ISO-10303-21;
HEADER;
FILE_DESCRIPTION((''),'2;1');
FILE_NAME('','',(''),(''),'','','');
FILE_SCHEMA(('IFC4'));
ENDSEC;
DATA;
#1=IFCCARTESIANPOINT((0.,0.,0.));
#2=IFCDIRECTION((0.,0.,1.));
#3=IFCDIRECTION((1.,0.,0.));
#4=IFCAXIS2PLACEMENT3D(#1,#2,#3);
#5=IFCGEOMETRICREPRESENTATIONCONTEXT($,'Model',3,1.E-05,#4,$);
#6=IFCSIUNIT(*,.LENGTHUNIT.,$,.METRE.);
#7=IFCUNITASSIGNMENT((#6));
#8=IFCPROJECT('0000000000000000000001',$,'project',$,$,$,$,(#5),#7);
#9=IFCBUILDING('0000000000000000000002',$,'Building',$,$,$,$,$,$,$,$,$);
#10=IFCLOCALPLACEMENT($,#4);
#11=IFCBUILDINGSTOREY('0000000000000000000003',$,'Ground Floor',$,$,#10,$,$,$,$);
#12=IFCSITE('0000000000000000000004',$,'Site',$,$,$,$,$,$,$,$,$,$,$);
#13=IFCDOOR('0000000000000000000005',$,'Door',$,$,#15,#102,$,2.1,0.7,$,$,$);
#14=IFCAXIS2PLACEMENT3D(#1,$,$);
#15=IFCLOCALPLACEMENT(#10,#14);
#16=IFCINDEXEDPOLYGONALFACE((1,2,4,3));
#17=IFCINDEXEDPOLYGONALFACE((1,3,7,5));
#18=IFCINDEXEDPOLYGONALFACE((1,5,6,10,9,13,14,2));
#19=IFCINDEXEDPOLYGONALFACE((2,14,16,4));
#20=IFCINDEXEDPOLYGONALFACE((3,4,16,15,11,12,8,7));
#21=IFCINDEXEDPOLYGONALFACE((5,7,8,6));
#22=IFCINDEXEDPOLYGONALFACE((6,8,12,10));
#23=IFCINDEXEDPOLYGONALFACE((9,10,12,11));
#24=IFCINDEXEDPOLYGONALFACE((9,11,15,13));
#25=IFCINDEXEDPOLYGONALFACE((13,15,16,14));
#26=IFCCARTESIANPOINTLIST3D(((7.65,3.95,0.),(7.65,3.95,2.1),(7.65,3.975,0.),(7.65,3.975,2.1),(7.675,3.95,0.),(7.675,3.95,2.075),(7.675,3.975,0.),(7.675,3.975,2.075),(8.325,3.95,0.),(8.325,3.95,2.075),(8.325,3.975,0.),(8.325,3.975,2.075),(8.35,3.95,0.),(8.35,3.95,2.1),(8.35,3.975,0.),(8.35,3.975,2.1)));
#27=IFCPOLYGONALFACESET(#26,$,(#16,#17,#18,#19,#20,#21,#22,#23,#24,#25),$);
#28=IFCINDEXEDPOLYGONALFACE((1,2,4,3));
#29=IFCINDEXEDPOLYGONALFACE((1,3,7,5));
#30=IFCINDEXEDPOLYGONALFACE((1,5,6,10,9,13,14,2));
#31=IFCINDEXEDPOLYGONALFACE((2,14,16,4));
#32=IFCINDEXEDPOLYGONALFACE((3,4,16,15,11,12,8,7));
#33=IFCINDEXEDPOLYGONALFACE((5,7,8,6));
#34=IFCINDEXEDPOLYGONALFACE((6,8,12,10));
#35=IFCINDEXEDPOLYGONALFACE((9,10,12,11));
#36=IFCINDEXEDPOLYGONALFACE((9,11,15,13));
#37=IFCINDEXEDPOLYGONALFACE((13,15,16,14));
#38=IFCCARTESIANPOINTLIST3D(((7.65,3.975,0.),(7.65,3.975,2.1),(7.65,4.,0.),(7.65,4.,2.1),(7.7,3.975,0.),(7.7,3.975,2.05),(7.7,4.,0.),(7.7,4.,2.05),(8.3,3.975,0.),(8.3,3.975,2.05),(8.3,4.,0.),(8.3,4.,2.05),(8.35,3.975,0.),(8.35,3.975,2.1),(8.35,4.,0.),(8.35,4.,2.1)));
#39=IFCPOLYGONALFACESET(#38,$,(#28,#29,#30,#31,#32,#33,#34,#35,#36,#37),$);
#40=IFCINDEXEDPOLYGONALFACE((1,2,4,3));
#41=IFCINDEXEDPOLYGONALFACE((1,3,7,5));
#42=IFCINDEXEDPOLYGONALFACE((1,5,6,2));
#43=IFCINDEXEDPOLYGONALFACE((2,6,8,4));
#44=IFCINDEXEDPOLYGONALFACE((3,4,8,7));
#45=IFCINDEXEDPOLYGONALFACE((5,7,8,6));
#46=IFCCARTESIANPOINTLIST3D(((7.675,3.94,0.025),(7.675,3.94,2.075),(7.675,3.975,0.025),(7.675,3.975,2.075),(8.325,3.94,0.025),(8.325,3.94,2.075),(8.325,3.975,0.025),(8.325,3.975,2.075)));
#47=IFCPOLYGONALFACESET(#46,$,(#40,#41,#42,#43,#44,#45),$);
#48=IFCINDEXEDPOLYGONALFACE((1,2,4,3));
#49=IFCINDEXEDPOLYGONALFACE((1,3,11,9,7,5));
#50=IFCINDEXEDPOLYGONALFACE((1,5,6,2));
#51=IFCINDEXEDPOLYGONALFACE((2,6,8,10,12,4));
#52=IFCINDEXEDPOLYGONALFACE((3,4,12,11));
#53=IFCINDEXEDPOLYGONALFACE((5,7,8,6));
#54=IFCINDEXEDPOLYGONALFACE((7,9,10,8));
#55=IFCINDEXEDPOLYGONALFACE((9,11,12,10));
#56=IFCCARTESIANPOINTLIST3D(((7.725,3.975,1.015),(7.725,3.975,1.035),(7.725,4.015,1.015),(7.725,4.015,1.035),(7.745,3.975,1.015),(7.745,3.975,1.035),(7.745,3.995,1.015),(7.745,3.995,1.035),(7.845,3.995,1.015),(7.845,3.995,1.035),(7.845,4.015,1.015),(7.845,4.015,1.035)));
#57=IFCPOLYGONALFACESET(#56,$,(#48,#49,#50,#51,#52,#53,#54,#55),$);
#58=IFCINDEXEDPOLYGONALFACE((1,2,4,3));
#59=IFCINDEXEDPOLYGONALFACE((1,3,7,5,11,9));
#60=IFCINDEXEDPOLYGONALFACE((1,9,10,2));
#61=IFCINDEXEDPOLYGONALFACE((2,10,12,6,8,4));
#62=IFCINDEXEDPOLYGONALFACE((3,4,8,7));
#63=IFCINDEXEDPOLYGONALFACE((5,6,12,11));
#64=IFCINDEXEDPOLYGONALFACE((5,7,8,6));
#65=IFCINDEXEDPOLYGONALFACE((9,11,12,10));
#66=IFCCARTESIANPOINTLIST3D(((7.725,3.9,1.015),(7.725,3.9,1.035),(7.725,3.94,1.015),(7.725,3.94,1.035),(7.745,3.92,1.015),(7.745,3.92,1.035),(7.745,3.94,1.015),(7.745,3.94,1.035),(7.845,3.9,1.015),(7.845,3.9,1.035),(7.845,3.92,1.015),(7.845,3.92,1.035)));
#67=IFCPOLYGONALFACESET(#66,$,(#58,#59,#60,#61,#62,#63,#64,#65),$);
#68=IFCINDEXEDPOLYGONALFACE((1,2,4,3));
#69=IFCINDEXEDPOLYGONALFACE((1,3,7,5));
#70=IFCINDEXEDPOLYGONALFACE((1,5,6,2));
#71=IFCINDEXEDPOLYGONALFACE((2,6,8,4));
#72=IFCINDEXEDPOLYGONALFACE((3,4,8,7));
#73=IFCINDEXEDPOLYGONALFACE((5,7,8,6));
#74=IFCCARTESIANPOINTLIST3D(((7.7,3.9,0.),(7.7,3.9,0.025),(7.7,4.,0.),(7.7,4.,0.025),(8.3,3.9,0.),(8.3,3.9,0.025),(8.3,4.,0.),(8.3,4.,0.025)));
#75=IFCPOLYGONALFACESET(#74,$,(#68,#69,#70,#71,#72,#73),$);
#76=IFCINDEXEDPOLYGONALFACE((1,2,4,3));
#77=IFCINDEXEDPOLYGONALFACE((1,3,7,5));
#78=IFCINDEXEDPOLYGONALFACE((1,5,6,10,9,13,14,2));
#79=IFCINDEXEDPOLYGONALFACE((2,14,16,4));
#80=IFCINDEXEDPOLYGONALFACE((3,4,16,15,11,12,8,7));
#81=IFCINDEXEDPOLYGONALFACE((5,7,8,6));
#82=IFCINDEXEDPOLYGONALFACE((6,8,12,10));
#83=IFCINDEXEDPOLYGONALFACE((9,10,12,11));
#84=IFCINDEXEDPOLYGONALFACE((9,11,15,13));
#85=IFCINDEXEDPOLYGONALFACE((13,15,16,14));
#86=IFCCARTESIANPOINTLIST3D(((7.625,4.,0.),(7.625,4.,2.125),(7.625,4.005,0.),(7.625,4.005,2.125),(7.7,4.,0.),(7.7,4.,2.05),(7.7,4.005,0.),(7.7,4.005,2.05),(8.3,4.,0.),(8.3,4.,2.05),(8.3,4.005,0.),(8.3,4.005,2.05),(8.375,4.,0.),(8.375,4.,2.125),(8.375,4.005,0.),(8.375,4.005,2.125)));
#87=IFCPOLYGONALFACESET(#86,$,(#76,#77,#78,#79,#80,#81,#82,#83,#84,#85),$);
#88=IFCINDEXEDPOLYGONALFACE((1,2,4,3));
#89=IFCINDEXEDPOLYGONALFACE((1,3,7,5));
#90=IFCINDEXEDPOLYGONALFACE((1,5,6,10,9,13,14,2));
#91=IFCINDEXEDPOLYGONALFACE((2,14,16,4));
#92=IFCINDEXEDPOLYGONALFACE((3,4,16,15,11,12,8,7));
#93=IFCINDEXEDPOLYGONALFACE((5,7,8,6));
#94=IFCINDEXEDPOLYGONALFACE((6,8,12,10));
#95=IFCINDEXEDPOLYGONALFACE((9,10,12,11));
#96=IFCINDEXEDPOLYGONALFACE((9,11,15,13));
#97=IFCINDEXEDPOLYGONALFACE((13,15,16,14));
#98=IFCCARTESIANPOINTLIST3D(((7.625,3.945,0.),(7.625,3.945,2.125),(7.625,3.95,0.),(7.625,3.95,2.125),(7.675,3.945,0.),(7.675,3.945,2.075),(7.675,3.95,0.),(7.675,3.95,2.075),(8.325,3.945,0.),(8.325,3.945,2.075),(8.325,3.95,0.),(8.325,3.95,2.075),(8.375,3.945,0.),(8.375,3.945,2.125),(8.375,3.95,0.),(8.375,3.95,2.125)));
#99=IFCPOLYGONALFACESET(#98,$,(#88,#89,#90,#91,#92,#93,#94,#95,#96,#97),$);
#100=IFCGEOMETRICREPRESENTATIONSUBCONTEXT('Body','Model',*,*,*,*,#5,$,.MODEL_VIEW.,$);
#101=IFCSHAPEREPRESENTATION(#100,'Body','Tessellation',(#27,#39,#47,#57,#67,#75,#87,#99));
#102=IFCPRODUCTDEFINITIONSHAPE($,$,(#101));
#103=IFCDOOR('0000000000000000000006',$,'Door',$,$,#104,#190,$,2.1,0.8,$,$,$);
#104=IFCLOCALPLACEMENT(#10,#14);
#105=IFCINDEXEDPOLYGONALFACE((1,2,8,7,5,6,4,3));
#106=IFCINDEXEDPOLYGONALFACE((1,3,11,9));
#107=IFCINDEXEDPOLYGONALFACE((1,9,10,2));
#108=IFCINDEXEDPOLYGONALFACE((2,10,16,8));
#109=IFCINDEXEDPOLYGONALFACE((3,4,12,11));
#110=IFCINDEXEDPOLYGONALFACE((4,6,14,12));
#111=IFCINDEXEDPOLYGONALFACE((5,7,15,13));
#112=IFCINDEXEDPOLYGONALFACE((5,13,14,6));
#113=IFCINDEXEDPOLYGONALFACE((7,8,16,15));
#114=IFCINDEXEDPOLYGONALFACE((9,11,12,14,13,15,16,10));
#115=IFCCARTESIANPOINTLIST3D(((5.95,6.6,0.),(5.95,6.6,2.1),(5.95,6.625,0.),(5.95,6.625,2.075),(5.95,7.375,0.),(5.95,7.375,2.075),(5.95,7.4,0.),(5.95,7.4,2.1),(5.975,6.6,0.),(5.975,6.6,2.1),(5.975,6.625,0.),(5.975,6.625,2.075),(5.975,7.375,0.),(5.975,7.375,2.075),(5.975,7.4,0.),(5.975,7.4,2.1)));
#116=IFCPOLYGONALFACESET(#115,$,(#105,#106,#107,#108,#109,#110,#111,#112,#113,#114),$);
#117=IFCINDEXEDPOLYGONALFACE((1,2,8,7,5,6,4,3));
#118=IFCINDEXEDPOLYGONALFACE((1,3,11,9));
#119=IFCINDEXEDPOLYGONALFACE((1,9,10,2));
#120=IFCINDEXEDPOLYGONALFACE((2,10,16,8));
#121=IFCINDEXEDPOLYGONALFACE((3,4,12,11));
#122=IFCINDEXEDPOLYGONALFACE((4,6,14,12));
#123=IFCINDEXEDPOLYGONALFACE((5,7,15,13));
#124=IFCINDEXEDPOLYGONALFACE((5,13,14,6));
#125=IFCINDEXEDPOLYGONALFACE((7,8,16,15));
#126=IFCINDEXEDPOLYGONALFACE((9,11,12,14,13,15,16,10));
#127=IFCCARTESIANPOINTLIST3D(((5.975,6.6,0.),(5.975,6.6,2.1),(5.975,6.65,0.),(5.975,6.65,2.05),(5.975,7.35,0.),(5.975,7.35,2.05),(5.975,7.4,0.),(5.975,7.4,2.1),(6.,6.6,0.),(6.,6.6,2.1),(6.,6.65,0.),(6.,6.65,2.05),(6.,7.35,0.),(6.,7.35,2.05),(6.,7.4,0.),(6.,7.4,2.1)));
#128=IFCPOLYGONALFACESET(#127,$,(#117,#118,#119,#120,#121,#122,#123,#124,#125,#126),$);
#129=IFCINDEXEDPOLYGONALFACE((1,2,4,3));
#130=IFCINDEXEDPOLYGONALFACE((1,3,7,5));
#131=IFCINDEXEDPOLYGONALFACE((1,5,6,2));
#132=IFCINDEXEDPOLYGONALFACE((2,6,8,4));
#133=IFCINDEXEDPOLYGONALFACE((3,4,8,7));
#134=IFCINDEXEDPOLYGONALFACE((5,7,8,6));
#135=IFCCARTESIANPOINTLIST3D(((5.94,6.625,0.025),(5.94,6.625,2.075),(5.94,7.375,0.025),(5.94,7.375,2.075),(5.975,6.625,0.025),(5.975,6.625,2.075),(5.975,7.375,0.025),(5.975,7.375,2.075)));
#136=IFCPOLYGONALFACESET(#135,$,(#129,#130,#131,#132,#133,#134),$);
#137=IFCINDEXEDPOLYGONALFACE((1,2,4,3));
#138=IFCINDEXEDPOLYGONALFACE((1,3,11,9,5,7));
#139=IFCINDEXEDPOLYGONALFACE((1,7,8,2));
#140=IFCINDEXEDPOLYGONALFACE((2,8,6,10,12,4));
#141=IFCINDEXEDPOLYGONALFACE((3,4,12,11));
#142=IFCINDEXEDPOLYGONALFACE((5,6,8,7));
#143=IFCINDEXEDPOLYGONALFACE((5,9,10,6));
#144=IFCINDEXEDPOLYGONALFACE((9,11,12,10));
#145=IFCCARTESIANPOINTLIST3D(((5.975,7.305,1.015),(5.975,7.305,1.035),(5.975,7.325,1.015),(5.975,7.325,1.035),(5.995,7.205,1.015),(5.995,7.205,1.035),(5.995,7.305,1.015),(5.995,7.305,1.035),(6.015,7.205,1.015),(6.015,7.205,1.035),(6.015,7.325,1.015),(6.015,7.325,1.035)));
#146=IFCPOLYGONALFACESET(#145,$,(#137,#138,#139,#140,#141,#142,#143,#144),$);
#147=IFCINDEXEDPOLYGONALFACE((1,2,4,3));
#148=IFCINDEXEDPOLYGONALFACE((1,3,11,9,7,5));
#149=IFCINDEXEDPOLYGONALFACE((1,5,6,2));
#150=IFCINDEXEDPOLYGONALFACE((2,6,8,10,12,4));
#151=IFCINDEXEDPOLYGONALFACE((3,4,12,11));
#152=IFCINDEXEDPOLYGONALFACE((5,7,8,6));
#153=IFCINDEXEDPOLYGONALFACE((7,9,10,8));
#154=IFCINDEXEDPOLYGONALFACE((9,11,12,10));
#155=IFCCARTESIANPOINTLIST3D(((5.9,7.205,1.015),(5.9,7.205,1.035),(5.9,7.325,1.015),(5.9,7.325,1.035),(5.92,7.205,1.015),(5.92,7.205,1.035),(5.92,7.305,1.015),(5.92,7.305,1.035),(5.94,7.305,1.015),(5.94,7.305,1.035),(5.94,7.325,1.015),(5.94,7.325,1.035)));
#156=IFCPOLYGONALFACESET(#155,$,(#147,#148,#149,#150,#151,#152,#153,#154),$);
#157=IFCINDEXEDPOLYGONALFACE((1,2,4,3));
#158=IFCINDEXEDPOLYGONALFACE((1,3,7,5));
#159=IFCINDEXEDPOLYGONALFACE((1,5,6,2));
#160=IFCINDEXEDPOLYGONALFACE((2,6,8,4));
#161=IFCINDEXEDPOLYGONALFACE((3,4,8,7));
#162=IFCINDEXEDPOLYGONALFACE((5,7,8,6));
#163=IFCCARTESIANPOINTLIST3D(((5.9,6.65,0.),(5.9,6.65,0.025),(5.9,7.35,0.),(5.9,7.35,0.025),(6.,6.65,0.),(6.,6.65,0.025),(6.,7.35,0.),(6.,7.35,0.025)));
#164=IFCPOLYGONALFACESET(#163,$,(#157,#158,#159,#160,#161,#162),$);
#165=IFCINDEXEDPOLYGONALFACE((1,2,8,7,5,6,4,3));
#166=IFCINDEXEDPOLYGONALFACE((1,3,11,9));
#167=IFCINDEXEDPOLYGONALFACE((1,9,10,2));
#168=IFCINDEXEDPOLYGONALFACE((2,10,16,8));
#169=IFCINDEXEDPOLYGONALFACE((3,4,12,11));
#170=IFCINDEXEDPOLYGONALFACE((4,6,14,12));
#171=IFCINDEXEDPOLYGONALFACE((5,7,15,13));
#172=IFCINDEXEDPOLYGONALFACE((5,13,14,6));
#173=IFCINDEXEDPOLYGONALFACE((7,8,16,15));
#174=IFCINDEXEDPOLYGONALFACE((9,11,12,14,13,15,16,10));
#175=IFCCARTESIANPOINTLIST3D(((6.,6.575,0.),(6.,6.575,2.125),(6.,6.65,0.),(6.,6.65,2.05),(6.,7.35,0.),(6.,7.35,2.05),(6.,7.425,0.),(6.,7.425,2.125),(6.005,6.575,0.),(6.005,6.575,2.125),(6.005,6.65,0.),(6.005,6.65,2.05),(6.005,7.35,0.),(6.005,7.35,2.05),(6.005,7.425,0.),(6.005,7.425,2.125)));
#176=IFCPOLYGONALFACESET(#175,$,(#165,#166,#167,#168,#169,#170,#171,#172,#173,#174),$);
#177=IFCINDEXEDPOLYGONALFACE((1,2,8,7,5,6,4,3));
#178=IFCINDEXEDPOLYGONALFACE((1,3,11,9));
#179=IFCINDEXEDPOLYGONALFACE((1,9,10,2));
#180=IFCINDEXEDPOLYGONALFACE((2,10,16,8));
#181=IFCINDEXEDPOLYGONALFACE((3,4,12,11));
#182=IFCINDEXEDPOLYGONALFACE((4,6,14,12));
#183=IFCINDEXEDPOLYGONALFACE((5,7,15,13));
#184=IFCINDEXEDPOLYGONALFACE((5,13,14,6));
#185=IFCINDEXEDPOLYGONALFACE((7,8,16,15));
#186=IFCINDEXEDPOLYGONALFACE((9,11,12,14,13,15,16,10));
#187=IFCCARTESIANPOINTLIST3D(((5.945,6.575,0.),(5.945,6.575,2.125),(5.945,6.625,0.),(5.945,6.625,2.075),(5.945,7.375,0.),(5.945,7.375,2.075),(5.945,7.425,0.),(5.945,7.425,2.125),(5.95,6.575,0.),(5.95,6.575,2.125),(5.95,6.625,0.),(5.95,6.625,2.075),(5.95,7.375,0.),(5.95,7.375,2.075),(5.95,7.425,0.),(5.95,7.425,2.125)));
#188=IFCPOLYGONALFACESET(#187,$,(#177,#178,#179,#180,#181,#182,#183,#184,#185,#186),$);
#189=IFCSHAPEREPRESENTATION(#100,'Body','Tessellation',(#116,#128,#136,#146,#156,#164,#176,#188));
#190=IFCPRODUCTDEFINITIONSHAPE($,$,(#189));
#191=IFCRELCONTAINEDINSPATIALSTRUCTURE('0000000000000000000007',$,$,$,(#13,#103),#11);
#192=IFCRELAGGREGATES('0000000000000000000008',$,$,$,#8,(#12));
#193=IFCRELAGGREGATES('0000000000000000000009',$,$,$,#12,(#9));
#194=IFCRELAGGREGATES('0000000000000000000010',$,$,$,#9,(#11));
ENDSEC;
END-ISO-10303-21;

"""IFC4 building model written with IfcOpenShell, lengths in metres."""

from ifc_helpers import new_model, si_unit, frame, origin_with_axes, place, context, subcontext, project, spatial, line, indexed_curve, outline, extrude, element, save


model = new_model("IFC4")

# Units and contexts
model_context = context("Model", 3, precision=1e-05, world=origin_with_axes())
body_context = subcontext(model_context, "Body", "Model", "MODEL_VIEW")
ifc_project = project(units=[si_unit("LENGTHUNIT", "METRE")], contexts=[model_context])

# Site, building, storey
site = spatial("IfcSite", under=ifc_project, Name="Site")
building = spatial("IfcBuilding", under=site, Name="Building")
storey_placement = place(None, origin_with_axes())
storey = spatial("IfcBuildingStorey", under=building, at=storey_placement, Name="Ground Floor")

# Doors
door_1_placement = place(storey_placement, frame((8.35, 4.0, 0.0), z_axis=(0.0, 0.0, 1.0), x_axis=(-1.0, 0.0, 0.0)))
element("IfcDoor", 1, at=door_1_placement, inside=storey, Name="Door", OverallHeight=2.1, OverallWidth=0.7, context=body_context, shape_type="SweptSolid", body=[
    extrude(outline(indexed_curve([(0.0, 0.0), (0.0, 2.1), (0.7, 2.1), (0.7, 0.0), (0.675, 0.0), (0.675, 2.075), (0.025, 2.075), (0.025, 0.0)], segments=[line(1, 2, 3, 4, 5, 6, 7, 8, 1)])), frame((0.0, 0.025, 0.0), z_axis=(0.0, -1.0, 0.0), x_axis=(1.0, 0.0, 0.0)), (0.0, 0.0, -1.0), 0.025),
    extrude(outline(indexed_curve([(0.0, 0.0), (0.0, 2.1), (0.7, 2.1), (0.7, 0.0), (0.65, 0.0), (0.65, 2.05), (0.05, 2.05), (0.05, 0.0)], segments=[line(1, 2, 3, 4, 5, 6, 7, 8, 1)])), frame((0.0, 0.0, 0.0), z_axis=(0.0, -1.0, 0.0), x_axis=(1.0, 0.0, 0.0)), (0.0, 0.0, -1.0), 0.025),
    extrude(outline(indexed_curve([(0.0, 0.0), (0.65, 0.0), (0.65, 0.035), (0.0, 0.035)], segments=[line(1, 2, 3, 4, 1)])), frame((0.025, 0.025, 0.025), z_axis=(0.0, 0.0, 1.0), x_axis=(1.0, 0.0, 0.0)), (0.0, 0.0, 1.0), 2.05),
    extrude(outline(indexed_curve([(0.0, 0.0), (0.0, -0.04), (-0.12, -0.04), (-0.12, -0.02), (-0.02, -0.02), (-0.02, 0.0)], segments=[line(1, 2, 3, 4, 5, 6, 1)])), frame((0.625, 0.025, 1.015), z_axis=(0.0, 0.0, 1.0), x_axis=(1.0, 0.0, 0.0)), (0.0, 0.0, 1.0), 0.02),
    extrude(outline(indexed_curve([(0.0, 0.0), (0.0, 0.04), (-0.12, 0.04), (-0.12, 0.02), (-0.02, 0.02), (-0.02, 0.0)], segments=[line(1, 2, 3, 4, 5, 6, 1)])), frame((0.625, 0.06, 1.015), z_axis=(0.0, 0.0, 1.0), x_axis=(1.0, 0.0, 0.0)), (0.0, 0.0, 1.0), 0.02),
    extrude(outline(indexed_curve([(0.0, 0.0), (0.6, 0.0), (0.6, 0.1), (0.0, 0.1)], segments=[line(1, 2, 3, 4, 1)])), frame((0.05, 0.0, 0.0), z_axis=(0.0, 0.0, 1.0), x_axis=(1.0, 0.0, 0.0)), (0.0, 0.0, 1.0), 0.025),
    extrude(outline(indexed_curve([(0.0, 0.0), (0.0, 2.125), (0.75, 2.125), (0.75, 0.0), (0.675, 0.0), (0.675, 2.05), (0.075, 2.05), (0.075, 0.0)], segments=[line(1, 2, 3, 4, 5, 6, 7, 8, 1)])), frame((-0.025, -0.005, 0.0), z_axis=(0.0, -1.0, 0.0), x_axis=(1.0, 0.0, 0.0)), (0.0, 0.0, -1.0), 0.005),
    extrude(outline(indexed_curve([(0.0, 0.0), (0.0, 2.125), (0.75, 2.125), (0.75, 0.0), (0.7, 0.0), (0.7, 2.075), (0.05, 2.075), (0.05, 0.0)], segments=[line(1, 2, 3, 4, 5, 6, 7, 8, 1)])), frame((-0.025, 0.05, 0.0), z_axis=(0.0, -1.0, 0.0), x_axis=(1.0, 0.0, 0.0)), (0.0, 0.0, -1.0), 0.005),
])
door_2_placement = place(storey_placement, frame((6.0, 6.6, 0.0), z_axis=(0.0, 0.0, 1.0), x_axis=(0.0, 1.0, 0.0)))
element("IfcDoor", 2, at=door_2_placement, inside=storey, Name="Door", OverallHeight=2.1, OverallWidth=0.8, context=body_context, shape_type="SweptSolid", body=[
    extrude(outline(indexed_curve([(0.0, 0.0), (0.0, 2.1), (0.8, 2.1), (0.8, 0.0), (0.775, 0.0), (0.775, 2.075), (0.025, 2.075), (0.025, 0.0)], segments=[line(1, 2, 3, 4, 5, 6, 7, 8, 1)])), frame((0.0, 0.025, 0.0), z_axis=(0.0, -1.0, 0.0), x_axis=(1.0, 0.0, 0.0)), (0.0, 0.0, -1.0), 0.025),
    extrude(outline(indexed_curve([(0.0, 0.0), (0.0, 2.1), (0.8, 2.1), (0.8, 0.0), (0.75, 0.0), (0.75, 2.05), (0.05, 2.05), (0.05, 0.0)], segments=[line(1, 2, 3, 4, 5, 6, 7, 8, 1)])), frame((0.0, 0.0, 0.0), z_axis=(0.0, -1.0, 0.0), x_axis=(1.0, 0.0, 0.0)), (0.0, 0.0, -1.0), 0.025),
    extrude(outline(indexed_curve([(0.0, 0.0), (0.75, 0.0), (0.75, 0.035), (0.0, 0.035)], segments=[line(1, 2, 3, 4, 1)])), frame((0.025, 0.025, 0.025), z_axis=(0.0, 0.0, 1.0), x_axis=(1.0, 0.0, 0.0)), (0.0, 0.0, 1.0), 2.05),
    extrude(outline(indexed_curve([(0.0, 0.0), (0.0, -0.04), (-0.12, -0.04), (-0.12, -0.02), (-0.02, -0.02), (-0.02, 0.0)], segments=[line(1, 2, 3, 4, 5, 6, 1)])), frame((0.725, 0.025, 1.015), z_axis=(0.0, 0.0, 1.0), x_axis=(1.0, 0.0, 0.0)), (0.0, 0.0, 1.0), 0.02),
    extrude(outline(indexed_curve([(0.0, 0.0), (0.0, 0.04), (-0.12, 0.04), (-0.12, 0.02), (-0.02, 0.02), (-0.02, 0.0)], segments=[line(1, 2, 3, 4, 5, 6, 1)])), frame((0.725, 0.06, 1.015), z_axis=(0.0, 0.0, 1.0), x_axis=(1.0, 0.0, 0.0)), (0.0, 0.0, 1.0), 0.02),
    extrude(outline(indexed_curve([(0.0, 0.0), (0.7, 0.0), (0.7, 0.1), (0.0, 0.1)], segments=[line(1, 2, 3, 4, 1)])), frame((0.05, 0.0, 0.0), z_axis=(0.0, 0.0, 1.0), x_axis=(1.0, 0.0, 0.0)), (0.0, 0.0, 1.0), 0.025),
    extrude(outline(indexed_curve([(0.0, 0.0), (0.0, 2.125), (0.85, 2.125), (0.85, 0.0), (0.775, 0.0), (0.775, 2.05), (0.075, 2.05), (0.075, 0.0)], segments=[line(1, 2, 3, 4, 5, 6, 7, 8, 1)])), frame((-0.025, -0.005, 0.0), z_axis=(0.0, -1.0, 0.0), x_axis=(1.0, 0.0, 0.0)), (0.0, 0.0, -1.0), 0.005),
    extrude(outline(indexed_curve([(0.0, 0.0), (0.0, 2.125), (0.85, 2.125), (0.85, 0.0), (0.8, 0.0), (0.8, 2.075), (0.05, 2.075), (0.05, 0.0)], segments=[line(1, 2, 3, 4, 5, 6, 7, 8, 1)])), frame((-0.025, 0.05, 0.0), z_axis=(0.0, -1.0, 0.0), x_axis=(1.0, 0.0, 0.0)), (0.0, 0.0, -1.0), 0.005),
])

save(model, "model.ifc")
